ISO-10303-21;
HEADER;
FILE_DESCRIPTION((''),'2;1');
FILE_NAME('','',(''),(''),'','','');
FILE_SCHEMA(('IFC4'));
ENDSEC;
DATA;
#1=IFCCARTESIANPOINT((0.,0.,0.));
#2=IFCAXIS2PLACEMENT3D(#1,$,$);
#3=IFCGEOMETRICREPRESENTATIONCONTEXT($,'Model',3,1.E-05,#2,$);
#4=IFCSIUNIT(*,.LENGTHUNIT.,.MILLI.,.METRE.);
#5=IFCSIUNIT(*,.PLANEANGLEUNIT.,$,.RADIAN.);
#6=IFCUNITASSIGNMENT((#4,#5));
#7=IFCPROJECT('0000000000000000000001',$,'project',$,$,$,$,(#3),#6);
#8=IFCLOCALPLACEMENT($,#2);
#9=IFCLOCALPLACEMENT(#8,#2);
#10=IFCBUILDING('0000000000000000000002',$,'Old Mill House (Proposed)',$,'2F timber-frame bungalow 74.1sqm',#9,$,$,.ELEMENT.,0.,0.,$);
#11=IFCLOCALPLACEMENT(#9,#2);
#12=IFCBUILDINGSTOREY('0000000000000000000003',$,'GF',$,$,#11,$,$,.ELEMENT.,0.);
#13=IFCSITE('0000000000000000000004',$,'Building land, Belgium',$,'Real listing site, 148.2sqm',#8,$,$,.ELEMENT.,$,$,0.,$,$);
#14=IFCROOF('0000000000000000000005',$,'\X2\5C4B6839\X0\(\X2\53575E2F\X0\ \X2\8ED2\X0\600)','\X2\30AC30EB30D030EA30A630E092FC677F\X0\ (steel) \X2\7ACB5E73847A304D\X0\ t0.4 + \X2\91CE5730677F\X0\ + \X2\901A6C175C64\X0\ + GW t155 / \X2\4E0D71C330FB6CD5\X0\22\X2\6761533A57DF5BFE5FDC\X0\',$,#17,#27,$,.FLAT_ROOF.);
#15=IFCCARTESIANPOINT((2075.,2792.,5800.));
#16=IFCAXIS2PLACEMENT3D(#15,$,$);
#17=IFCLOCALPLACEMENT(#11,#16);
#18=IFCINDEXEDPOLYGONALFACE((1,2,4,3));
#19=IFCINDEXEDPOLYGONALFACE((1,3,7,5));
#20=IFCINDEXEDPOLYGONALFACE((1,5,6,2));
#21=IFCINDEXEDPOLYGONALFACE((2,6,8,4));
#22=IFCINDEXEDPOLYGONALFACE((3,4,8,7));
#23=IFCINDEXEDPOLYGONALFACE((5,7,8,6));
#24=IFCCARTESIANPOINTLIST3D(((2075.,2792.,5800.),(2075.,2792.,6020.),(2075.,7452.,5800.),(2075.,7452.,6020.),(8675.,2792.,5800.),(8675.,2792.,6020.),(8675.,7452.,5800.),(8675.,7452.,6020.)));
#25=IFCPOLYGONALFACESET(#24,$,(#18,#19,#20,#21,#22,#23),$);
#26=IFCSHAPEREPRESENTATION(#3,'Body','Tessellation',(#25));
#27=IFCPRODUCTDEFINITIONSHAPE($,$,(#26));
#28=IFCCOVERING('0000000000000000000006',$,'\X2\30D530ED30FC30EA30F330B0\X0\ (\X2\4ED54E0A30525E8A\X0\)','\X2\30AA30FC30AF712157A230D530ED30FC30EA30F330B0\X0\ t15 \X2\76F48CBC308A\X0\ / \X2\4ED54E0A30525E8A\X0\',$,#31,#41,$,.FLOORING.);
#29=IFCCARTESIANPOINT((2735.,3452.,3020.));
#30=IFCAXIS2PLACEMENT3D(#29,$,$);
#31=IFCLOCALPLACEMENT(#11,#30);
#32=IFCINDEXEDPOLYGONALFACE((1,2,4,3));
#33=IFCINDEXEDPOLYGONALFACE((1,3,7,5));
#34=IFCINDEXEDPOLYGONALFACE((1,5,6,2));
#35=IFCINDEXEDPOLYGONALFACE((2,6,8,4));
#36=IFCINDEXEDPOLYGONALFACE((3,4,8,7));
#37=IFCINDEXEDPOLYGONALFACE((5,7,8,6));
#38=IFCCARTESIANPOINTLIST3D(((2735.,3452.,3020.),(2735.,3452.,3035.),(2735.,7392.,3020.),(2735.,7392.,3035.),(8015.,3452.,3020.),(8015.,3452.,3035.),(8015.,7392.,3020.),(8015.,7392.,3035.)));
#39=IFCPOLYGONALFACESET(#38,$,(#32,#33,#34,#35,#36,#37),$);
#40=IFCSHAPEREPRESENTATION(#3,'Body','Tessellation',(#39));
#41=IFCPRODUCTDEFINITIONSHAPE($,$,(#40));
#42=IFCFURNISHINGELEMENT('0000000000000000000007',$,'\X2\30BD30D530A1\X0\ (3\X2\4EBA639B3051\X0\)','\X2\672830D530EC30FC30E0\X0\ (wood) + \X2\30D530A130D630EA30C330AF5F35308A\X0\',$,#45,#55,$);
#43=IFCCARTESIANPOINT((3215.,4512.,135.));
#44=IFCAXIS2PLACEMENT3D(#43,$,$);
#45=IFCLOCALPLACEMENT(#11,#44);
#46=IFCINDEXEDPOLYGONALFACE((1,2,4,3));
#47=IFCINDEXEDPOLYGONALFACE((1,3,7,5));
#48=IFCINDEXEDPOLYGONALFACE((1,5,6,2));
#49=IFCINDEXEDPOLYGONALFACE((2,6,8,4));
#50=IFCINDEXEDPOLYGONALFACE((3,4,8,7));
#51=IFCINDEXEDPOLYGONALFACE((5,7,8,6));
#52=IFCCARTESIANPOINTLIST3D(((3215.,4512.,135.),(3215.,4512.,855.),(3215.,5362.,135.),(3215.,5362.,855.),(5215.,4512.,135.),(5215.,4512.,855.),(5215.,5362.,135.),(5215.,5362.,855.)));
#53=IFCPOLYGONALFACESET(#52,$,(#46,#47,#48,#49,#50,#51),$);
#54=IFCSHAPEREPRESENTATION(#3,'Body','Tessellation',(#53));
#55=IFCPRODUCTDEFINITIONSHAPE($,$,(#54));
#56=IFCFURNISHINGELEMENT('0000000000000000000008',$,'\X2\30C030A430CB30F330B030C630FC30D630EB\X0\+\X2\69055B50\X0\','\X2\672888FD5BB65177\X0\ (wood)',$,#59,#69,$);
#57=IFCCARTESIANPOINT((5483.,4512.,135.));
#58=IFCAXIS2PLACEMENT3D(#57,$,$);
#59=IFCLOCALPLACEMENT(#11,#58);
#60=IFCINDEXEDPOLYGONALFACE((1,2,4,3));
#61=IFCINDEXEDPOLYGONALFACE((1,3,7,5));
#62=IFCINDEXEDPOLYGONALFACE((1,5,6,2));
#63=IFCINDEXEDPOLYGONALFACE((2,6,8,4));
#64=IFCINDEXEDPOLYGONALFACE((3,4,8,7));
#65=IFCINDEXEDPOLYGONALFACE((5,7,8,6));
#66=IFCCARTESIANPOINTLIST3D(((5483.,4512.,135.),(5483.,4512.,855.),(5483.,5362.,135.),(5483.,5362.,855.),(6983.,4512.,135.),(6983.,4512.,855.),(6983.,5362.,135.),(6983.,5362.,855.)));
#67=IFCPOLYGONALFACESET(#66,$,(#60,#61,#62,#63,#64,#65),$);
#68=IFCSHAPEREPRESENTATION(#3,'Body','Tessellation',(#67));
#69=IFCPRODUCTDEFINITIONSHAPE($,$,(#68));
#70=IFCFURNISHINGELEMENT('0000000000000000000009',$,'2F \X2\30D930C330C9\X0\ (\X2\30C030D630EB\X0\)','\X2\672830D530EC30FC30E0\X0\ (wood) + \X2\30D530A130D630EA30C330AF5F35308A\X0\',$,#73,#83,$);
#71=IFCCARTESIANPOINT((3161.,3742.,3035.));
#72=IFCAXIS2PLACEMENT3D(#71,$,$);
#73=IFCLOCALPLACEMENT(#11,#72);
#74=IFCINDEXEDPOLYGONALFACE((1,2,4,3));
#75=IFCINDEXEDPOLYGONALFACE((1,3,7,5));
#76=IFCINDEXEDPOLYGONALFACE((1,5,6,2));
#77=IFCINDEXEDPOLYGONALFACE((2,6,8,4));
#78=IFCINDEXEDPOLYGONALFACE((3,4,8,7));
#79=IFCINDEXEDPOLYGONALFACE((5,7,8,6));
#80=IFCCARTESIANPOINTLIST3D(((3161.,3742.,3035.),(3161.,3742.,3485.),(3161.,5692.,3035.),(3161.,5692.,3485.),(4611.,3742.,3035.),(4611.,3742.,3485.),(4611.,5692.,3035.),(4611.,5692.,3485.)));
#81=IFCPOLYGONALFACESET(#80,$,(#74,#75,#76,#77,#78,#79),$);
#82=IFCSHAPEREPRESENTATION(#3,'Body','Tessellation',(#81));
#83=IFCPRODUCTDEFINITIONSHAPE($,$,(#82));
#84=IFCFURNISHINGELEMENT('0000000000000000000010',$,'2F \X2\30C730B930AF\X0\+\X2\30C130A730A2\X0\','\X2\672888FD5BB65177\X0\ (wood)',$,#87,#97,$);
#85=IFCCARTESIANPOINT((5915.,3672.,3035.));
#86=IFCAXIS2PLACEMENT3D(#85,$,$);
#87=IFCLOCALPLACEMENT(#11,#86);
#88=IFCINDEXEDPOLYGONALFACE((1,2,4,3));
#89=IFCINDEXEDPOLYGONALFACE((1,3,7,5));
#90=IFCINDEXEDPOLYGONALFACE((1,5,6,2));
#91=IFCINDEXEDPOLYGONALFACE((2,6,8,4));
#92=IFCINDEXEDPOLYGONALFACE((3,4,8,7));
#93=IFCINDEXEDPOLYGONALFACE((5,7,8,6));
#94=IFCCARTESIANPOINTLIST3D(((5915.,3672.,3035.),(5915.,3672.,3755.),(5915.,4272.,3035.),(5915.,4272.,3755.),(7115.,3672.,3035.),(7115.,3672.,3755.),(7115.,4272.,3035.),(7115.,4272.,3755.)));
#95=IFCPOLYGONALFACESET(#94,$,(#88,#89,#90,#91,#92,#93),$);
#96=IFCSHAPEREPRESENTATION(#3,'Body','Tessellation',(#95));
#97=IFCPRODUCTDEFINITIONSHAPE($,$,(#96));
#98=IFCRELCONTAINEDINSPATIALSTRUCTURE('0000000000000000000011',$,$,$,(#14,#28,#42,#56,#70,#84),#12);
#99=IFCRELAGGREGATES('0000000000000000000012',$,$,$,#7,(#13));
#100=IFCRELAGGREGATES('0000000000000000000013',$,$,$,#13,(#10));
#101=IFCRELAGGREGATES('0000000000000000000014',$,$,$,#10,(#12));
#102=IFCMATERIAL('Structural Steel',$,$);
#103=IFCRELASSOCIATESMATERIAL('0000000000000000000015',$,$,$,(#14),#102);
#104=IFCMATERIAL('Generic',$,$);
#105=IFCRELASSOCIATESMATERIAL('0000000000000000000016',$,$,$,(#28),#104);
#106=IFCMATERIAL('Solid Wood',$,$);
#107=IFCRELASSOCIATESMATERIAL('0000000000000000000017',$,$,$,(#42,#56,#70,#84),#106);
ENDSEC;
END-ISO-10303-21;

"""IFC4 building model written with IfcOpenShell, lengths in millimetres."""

from ifc_helpers import new_model, si_unit, frame, frame_2d, origin, place, context, project, spatial, rectangle, extrude, material, element, save


model = new_model("IFC4")

# Units and contexts
model_context = context("Model", 3, precision=1e-05, world=origin())
ifc_project = project(units=[si_unit("LENGTHUNIT", "METRE", prefix="MILLI"), si_unit("PLANEANGLEUNIT", "RADIAN")], contexts=[model_context])

# Site, building, storey
site_placement = place(None, origin())
site = spatial("IfcSite", under=ifc_project, at=site_placement, Name="Building land, Belgium", ObjectType="Real listing site, 148.2sqm", CompositionType="ELEMENT", RefElevation=0.0)
building_placement = place(site_placement, origin())
building = spatial("IfcBuilding", under=site, at=building_placement, Name="Old Mill House (Proposed)", ObjectType="2F timber-frame bungalow 74.1sqm", CompositionType="ELEMENT", ElevationOfRefHeight=0.0, ElevationOfTerrain=0.0)
storey_placement = place(building_placement, origin())
storey = spatial("IfcBuildingStorey", under=building, at=storey_placement, Name="GF", CompositionType="ELEMENT", Elevation=0.0)

# Shared definitions
ifc_material_1 = material(Name="Solid Wood")

# Roof
ifc_material_2 = material(Name="Structural Steel")
for number, where, name in (
    (1, (2075.0, 2792.0, 5800.0), "屋根(南帯 軒600)"),
):
    element("IfcRoof", number, at=place(storey_placement, frame(where)), inside=storey, material=ifc_material_2, Name=name, Description="ガルバリウム鋼板 (steel) 立平葺き t0.4 + 野地板 + 通気層 + GW t155 / 不燃・法22条区域対応", PredefinedType="FLAT_ROOF", context=model_context, shape_type="SweptSolid", body=[
        extrude(rectangle(XDim=6600.0, YDim=4660.0, at=frame_2d((3300.0, 2330.0))), frame((2075.0, 2792.0, 5800.0)), (0.0, 0.0, 1.0), 220.0),
    ])

# Covering
ifc_material_3 = material(Name="Generic")
covering_placement = place(storey_placement, frame((2735.0, 3452.0, 3020.0)))
element("IfcCovering", 2, at=covering_placement, inside=storey, material=ifc_material_3, Name="フローリング (仕上げ床)", Description="オーク無垢フローリング t15 直貼り / 仕上げ床", PredefinedType="FLOORING", context=model_context, shape_type="SweptSolid", body=[
    extrude(rectangle(XDim=5280.0, YDim=3940.0, at=frame_2d((2640.0, 1970.0))), frame((2735.0, 3452.0, 3020.0)), (0.0, 0.0, 1.0), 15.0),
])

# Furnishing elements
furnishing_1_placement = place(storey_placement, frame((3215.0, 4512.0, 135.0)))
element("IfcFurnishingElement", 3, at=furnishing_1_placement, inside=storey, material=ifc_material_1, Name="ソファ (3人掛け)", Description="木フレーム (wood) + ファブリック張り", context=model_context, shape_type="SweptSolid", body=[
    extrude(rectangle(XDim=2000.0, YDim=850.0, at=frame_2d((1000.0, 425.0))), frame((3215.0, 4512.0, 135.0)), (0.0, 0.0, 1.0), 720.0),
])
furnishing_2_placement = place(storey_placement, frame((5483.0, 4512.0, 135.0)))
element("IfcFurnishingElement", 4, at=furnishing_2_placement, inside=storey, material=ifc_material_1, Name="ダイニングテーブル+椅子", Description="木製家具 (wood)", context=model_context, shape_type="SweptSolid", body=[
    extrude(rectangle(XDim=1500.0, YDim=850.0, at=frame_2d((750.0, 425.0))), frame((5483.0, 4512.0, 135.0)), (0.0, 0.0, 1.0), 720.0),
])
furnishing_3_placement = place(storey_placement, frame((3161.0, 3742.0, 3035.0)))
element("IfcFurnishingElement", 5, at=furnishing_3_placement, inside=storey, material=ifc_material_1, Name="2F ベッド (ダブル)", Description="木フレーム (wood) + ファブリック張り", context=model_context, shape_type="SweptSolid", body=[
    extrude(rectangle(XDim=1450.0, YDim=1950.0, at=frame_2d((725.0, 975.0))), frame((3161.0, 3742.0, 3035.0)), (0.0, 0.0, 1.0), 450.0),
])
furnishing_4_placement = place(storey_placement, frame((5915.0, 3672.0, 3035.0)))
element("IfcFurnishingElement", 6, at=furnishing_4_placement, inside=storey, material=ifc_material_1, Name="2F デスク+チェア", Description="木製家具 (wood)", context=model_context, shape_type="SweptSolid", body=[
    extrude(rectangle(XDim=1200.0, YDim=600.0, at=frame_2d((600.0, 300.0))), frame((5915.0, 3672.0, 3035.0)), (0.0, 0.0, 1.0), 720.0),
])

save(model, "model.ifc")
